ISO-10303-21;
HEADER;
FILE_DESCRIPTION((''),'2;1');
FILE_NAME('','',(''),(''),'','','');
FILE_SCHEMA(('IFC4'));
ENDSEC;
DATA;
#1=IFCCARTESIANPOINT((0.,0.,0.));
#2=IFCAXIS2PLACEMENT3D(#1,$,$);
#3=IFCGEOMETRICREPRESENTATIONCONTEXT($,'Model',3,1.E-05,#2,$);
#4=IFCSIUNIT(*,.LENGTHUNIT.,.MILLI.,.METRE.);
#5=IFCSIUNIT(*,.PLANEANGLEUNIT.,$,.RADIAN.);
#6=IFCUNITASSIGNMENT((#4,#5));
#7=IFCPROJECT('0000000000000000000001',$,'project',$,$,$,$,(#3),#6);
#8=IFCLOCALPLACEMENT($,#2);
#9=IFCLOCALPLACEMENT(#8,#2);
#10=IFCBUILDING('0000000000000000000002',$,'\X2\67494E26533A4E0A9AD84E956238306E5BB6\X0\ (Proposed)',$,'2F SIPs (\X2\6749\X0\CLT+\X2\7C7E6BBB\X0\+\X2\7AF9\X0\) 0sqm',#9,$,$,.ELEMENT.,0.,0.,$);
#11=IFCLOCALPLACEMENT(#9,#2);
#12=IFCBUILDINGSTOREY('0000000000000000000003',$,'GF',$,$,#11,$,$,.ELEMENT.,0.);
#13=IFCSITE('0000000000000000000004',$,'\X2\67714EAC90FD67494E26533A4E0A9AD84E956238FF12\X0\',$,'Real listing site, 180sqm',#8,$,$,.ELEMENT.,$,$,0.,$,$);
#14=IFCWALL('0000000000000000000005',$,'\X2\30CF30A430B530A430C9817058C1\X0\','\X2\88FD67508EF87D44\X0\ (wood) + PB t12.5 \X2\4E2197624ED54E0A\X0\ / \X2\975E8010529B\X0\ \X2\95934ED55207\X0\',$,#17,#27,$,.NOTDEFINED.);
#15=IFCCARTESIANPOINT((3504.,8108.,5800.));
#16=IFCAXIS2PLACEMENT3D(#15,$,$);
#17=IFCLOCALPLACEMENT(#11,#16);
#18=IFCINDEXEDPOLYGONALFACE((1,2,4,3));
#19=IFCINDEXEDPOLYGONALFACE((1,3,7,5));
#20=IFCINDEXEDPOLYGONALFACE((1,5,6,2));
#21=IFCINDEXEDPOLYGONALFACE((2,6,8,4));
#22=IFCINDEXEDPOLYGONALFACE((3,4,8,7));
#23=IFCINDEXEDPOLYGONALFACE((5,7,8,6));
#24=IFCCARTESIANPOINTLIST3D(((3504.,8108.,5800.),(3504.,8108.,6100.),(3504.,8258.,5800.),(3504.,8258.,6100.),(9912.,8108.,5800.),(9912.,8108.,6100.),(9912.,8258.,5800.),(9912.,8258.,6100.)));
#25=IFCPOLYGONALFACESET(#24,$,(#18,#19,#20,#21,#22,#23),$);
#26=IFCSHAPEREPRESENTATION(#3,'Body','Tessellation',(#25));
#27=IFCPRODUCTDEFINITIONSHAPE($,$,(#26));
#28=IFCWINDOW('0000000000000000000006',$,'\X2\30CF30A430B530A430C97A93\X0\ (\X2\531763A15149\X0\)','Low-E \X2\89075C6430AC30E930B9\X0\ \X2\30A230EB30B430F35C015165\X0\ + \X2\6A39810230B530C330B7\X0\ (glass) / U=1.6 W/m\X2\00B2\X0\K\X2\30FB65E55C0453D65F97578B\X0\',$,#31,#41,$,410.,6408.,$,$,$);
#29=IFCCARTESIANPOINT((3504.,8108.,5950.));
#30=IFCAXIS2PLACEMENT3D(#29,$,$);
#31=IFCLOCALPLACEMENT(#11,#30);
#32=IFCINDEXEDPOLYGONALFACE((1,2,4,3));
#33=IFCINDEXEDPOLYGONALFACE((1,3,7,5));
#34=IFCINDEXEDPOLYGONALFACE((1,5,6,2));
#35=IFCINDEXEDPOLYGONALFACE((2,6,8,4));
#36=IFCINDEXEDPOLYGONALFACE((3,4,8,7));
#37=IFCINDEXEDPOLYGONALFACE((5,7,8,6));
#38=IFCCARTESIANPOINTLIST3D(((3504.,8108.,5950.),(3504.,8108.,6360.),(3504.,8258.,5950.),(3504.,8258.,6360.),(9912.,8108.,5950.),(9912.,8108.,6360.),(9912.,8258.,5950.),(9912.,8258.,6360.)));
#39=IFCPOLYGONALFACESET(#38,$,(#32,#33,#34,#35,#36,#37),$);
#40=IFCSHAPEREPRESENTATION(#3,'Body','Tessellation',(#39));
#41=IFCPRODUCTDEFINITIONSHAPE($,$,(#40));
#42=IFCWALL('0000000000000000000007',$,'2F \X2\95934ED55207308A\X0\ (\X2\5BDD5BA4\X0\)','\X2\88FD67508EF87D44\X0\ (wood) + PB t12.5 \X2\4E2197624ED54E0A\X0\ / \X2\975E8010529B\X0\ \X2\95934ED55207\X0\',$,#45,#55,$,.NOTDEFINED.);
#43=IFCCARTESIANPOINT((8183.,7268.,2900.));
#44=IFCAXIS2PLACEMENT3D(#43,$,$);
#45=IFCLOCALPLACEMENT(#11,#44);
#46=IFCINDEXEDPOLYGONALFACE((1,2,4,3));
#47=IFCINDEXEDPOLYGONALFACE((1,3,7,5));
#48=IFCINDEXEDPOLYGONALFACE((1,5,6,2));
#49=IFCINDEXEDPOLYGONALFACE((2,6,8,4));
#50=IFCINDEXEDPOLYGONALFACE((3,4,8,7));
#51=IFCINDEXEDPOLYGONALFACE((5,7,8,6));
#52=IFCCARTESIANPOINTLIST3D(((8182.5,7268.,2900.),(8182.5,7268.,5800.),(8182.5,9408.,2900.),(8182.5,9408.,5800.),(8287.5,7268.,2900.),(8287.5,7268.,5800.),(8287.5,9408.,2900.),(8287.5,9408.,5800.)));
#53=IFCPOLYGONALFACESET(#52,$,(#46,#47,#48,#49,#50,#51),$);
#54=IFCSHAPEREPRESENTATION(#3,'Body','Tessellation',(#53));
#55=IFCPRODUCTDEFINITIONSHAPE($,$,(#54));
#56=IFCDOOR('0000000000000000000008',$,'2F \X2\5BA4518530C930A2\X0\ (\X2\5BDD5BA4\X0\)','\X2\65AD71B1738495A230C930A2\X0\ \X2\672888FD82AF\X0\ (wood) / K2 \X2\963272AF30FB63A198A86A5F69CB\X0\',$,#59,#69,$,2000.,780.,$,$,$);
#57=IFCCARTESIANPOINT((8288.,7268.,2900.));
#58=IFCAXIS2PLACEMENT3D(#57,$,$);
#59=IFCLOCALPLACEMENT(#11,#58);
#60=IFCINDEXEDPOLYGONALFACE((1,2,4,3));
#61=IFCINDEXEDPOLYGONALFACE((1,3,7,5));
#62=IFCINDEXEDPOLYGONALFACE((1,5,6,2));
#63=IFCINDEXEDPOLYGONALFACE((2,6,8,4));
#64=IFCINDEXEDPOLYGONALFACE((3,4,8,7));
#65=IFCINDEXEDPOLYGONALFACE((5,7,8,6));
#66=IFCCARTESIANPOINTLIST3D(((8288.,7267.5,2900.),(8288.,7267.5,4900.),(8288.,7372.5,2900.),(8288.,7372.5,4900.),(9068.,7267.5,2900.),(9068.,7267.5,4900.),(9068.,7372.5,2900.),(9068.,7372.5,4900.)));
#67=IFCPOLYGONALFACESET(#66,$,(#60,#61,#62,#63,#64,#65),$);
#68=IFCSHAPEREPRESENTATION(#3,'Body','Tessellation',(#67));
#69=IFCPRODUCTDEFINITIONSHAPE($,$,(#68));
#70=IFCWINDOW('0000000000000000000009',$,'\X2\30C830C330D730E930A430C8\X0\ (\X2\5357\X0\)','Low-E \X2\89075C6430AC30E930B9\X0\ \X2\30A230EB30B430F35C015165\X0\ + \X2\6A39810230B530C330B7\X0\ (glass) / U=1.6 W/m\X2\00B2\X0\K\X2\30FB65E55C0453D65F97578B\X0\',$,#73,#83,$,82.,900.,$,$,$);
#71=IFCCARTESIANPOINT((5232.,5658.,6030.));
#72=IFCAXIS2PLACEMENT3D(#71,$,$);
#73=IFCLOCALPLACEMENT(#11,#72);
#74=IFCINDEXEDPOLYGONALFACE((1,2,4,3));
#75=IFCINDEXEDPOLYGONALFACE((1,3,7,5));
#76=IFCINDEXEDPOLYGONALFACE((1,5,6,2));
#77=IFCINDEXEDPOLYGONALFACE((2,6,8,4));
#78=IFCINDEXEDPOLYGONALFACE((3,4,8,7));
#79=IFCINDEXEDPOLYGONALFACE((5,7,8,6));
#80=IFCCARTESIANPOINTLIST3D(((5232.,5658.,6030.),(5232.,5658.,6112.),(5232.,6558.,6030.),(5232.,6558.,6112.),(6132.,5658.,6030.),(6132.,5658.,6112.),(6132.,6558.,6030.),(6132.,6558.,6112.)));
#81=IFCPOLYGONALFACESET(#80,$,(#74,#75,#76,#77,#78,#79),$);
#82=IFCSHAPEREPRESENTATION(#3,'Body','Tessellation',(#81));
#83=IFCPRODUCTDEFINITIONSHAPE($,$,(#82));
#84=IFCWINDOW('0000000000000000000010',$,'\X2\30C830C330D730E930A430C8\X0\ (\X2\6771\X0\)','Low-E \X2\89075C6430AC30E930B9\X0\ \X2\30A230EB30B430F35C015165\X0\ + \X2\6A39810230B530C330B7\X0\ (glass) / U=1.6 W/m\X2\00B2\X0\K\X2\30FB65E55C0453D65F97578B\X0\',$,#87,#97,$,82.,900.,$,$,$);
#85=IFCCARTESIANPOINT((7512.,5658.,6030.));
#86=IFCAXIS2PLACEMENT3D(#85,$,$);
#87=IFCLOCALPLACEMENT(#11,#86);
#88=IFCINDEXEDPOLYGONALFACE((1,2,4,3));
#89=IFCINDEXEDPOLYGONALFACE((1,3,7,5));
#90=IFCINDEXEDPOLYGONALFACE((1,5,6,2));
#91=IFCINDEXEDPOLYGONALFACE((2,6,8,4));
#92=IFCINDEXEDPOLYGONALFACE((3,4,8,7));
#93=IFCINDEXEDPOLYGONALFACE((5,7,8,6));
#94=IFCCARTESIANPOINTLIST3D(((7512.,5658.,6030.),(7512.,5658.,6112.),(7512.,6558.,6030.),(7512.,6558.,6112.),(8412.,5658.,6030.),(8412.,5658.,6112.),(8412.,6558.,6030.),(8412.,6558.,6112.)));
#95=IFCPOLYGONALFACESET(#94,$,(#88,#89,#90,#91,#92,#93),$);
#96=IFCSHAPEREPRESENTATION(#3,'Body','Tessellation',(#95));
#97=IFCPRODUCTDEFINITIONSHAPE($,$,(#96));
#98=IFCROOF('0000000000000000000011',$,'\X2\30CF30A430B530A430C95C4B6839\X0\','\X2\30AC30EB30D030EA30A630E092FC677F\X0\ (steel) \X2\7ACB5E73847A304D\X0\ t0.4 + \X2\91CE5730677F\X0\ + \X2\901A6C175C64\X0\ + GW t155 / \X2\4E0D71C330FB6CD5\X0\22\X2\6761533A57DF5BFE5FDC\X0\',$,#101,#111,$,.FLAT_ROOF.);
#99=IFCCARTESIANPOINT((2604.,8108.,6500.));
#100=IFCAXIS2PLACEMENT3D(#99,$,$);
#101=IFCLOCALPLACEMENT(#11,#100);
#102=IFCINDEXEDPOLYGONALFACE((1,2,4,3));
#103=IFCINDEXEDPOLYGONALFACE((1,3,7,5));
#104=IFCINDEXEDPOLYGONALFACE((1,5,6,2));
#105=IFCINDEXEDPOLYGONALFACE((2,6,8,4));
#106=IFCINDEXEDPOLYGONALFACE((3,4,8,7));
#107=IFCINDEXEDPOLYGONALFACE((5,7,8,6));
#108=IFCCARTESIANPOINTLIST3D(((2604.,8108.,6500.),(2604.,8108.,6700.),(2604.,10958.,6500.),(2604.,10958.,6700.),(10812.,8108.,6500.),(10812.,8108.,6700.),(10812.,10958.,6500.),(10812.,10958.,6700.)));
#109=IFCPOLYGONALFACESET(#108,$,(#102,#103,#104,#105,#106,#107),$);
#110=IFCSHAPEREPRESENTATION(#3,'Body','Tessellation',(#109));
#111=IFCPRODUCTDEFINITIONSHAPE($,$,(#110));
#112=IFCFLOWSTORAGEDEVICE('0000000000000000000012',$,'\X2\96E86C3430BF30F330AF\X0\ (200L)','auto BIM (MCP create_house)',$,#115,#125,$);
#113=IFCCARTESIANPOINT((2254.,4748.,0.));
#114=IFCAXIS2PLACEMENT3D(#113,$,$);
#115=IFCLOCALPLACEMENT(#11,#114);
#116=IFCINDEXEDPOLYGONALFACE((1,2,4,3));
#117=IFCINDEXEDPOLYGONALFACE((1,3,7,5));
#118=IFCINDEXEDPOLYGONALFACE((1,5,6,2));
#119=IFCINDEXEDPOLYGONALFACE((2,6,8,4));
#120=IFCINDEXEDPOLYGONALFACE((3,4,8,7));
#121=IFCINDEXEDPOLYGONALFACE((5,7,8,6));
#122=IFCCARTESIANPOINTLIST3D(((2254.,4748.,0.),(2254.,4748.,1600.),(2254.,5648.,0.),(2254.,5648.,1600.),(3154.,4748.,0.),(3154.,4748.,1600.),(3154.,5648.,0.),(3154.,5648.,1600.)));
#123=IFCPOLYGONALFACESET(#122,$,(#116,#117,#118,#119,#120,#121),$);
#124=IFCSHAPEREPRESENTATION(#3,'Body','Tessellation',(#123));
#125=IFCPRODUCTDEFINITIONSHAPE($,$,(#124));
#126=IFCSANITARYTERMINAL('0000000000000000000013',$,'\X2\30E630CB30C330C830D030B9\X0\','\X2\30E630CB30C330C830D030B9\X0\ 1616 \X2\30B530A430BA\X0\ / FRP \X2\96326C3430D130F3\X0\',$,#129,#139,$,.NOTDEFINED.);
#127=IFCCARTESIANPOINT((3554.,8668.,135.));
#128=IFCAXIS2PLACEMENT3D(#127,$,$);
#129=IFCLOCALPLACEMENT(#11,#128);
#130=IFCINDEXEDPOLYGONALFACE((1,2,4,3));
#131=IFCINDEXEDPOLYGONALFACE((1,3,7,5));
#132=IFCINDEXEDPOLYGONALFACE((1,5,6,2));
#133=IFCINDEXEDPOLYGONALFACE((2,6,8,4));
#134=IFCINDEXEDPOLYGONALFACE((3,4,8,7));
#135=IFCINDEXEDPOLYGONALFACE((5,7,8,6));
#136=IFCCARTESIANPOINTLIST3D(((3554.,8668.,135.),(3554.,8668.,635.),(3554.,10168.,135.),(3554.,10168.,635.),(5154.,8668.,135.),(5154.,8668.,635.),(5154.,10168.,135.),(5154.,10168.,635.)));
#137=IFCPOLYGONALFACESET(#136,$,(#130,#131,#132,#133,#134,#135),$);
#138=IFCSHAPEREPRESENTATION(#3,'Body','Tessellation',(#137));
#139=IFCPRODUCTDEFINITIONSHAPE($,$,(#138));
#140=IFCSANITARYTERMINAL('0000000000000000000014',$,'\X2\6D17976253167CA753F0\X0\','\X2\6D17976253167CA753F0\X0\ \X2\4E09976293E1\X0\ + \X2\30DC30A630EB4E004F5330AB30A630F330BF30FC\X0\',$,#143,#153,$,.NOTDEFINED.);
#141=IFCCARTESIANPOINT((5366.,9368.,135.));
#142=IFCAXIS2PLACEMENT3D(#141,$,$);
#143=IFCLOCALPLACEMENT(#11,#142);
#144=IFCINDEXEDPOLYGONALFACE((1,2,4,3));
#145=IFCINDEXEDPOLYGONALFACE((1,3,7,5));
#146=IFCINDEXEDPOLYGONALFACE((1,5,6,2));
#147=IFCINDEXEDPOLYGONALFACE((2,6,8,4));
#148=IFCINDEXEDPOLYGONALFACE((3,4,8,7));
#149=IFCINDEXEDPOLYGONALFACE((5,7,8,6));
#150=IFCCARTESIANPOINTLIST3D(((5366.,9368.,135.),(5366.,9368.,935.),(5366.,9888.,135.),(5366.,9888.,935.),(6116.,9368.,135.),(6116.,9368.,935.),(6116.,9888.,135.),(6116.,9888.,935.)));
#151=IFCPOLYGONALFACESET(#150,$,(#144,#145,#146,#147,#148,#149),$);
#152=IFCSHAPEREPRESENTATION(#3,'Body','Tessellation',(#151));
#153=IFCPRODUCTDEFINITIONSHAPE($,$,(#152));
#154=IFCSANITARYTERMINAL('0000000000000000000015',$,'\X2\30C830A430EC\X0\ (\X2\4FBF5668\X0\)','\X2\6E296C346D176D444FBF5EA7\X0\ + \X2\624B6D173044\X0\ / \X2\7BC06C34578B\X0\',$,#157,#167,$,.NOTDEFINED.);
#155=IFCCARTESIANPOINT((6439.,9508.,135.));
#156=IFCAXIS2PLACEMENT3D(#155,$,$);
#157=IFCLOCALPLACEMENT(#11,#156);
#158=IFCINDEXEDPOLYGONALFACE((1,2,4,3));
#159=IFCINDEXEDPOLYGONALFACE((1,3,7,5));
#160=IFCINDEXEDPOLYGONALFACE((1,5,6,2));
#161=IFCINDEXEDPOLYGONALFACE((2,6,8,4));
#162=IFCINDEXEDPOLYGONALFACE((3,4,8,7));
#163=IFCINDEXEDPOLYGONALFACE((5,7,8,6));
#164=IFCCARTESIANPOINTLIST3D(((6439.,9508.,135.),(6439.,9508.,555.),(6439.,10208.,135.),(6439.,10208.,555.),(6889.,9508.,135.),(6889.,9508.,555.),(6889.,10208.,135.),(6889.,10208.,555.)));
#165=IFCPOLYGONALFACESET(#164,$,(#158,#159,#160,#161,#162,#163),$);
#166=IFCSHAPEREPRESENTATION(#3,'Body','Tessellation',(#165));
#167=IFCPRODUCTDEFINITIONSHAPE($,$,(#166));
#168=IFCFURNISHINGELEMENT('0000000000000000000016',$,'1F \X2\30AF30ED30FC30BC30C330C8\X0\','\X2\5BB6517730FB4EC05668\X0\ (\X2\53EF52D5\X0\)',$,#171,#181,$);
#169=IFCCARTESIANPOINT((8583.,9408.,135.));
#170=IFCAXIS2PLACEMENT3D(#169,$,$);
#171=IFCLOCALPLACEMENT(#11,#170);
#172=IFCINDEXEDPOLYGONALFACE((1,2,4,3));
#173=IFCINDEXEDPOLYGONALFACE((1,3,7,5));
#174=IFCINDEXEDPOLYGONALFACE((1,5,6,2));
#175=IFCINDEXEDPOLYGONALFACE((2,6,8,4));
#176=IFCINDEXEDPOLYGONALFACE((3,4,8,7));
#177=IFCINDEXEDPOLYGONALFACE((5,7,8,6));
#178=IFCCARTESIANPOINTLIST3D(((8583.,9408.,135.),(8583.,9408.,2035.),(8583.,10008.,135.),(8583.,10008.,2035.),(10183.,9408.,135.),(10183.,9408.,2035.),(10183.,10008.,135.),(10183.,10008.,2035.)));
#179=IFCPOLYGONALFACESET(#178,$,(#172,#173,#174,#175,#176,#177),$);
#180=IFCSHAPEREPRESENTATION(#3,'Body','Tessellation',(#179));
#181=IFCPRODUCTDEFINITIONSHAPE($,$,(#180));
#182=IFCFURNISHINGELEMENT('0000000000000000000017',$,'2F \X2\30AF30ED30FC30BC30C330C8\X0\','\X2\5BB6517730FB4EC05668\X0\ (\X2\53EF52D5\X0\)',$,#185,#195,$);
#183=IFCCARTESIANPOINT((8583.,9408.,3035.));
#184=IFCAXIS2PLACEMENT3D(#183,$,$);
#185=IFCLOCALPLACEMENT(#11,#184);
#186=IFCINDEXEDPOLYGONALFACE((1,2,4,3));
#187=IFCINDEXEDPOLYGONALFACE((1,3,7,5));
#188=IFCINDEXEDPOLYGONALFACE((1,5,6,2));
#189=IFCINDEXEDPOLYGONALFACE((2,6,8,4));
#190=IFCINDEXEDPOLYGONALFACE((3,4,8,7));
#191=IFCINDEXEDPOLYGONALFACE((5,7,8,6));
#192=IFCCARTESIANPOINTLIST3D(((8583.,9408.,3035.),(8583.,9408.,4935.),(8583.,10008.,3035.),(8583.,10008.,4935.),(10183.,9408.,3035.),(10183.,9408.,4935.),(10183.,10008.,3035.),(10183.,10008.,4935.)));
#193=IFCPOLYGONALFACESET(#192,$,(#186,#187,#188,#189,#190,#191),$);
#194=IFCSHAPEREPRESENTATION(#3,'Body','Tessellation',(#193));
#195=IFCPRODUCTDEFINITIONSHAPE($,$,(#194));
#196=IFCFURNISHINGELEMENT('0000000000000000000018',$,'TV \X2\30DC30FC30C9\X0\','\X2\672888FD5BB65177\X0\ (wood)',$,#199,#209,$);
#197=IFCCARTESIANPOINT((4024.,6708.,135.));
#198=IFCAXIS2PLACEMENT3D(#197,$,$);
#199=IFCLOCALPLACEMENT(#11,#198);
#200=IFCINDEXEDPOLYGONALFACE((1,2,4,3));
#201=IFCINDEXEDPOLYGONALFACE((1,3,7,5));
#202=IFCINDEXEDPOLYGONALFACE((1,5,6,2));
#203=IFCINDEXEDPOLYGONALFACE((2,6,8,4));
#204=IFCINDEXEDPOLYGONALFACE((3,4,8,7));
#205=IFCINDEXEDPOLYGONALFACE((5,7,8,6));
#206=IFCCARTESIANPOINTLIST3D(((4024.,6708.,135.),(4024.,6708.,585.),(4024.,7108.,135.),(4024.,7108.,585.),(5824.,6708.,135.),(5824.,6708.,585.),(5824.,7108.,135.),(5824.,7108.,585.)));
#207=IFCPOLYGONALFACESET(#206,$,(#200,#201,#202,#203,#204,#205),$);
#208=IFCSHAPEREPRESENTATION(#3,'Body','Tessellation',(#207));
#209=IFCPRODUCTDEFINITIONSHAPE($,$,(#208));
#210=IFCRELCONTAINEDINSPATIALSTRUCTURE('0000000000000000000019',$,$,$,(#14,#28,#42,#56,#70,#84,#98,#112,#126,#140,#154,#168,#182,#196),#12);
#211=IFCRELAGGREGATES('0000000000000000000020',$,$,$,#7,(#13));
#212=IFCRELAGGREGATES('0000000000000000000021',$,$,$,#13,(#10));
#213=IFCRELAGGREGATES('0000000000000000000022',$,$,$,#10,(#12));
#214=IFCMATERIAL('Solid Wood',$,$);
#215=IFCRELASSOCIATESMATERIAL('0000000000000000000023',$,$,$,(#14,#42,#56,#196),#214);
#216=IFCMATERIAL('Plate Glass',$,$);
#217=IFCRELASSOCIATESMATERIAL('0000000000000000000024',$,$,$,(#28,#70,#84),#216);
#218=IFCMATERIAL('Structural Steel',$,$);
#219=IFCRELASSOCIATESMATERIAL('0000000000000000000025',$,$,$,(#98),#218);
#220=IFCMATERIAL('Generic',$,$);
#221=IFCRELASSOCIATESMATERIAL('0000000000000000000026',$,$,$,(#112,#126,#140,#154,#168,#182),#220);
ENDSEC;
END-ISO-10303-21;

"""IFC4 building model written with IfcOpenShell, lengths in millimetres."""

from ifc_helpers import new_model, si_unit, frame, frame_2d, origin, place, context, project, spatial, rectangle, extrude, material, element, fill, save


model = new_model("IFC4")

# Units and contexts
model_context = context("Model", 3, precision=1e-05, world=origin())
ifc_project = project(units=[si_unit("LENGTHUNIT", "METRE", prefix="MILLI"), si_unit("PLANEANGLEUNIT", "RADIAN")], contexts=[model_context])

# Site, building, storey
site_placement = place(None, origin())
site = spatial("IfcSite", under=ifc_project, at=site_placement, Name="東京都杉並区上高井戸２", ObjectType="Real listing site, 180sqm", CompositionType="ELEMENT", RefElevation=0.0)
building_placement = place(site_placement, origin())
building = spatial("IfcBuilding", under=site, at=building_placement, Name="杉並区上高井戸の家 (Proposed)", ObjectType="2F SIPs (杉CLT+籾殻+竹) 0sqm", CompositionType="ELEMENT", ElevationOfRefHeight=0.0, ElevationOfTerrain=0.0)
storey_placement = place(building_placement, origin())
storey = spatial("IfcBuildingStorey", under=building, at=storey_placement, Name="GF", CompositionType="ELEMENT", Elevation=0.0)

# Shared definitions
ifc_material_1 = material(Name="Solid Wood")
ifc_material_2 = material(Name="Plate Glass")

# Wall, opening, window
wall_1_placement = place(storey_placement, frame((3504.0, 8108.0, 5800.0)))
wall_1 = element("IfcWall", 1, at=wall_1_placement, inside=storey, material=ifc_material_1, Name="ハイサイド腰壁", Description="製材軸組 (wood) + PB t12.5 両面仕上 / 非耐力 間仕切", PredefinedType="NOTDEFINED", context=model_context, shape_type="SweptSolid", body=[
    extrude(rectangle(XDim=6408.0, YDim=150.0, at=frame_2d((3204.0, 75.0))), frame((3504.0, 8108.0, 5800.0)), (0.0, 0.0, 1.0), 700.0),
])
opening_1_placement = place(storey_placement, frame((3504.0, 8108.0, 5950.0)))
opening_1 = element("IfcOpeningElement", 2, at=opening_1_placement, cuts=wall_1, PredefinedType="NOTDEFINED", context=model_context, shape_type="SweptSolid", body=[
    extrude(rectangle(XDim=6408.0, YDim=150.0, at=frame_2d((3204.0, 75.0))), frame((3504.0, 8108.0, 5950.0)), (0.0, 0.0, 1.0), 410.0),
])
window_1_placement = place(storey_placement, frame((3504.0, 8108.0, 5950.0)))
window_1 = element("IfcWindow", 3, at=window_1_placement, inside=storey, material=ifc_material_2, Name="ハイサイド窓 (北採光)", Description="Low-E 複層ガラス アルゴン封入 + 樹脂サッシ (glass) / U=1.6 W/m²K・日射取得型", OverallHeight=410.0, OverallWidth=6408.0, context=model_context, shape_type="SweptSolid", body=[
    extrude(rectangle(XDim=6408.0, YDim=150.0, at=frame_2d((3204.0, 75.0))), frame((3504.0, 8108.0, 5950.0)), (0.0, 0.0, 1.0), 410.0),
])
fill(opening_1, window_1)

# Wall
wall_2_placement = place(storey_placement, frame((8183.0, 7268.0, 2900.0)))
element("IfcWall", 4, at=wall_2_placement, inside=storey, material=ifc_material_1, Name="2F 間仕切り (寝室)", Description="製材軸組 (wood) + PB t12.5 両面仕上 / 非耐力 間仕切", PredefinedType="NOTDEFINED", context=model_context, shape_type="SweptSolid", body=[
    extrude(rectangle(XDim=105.0, YDim=2140.0, at=frame_2d((52.0, 1070.0))), frame((8183.0, 7268.0, 2900.0)), (0.0, 0.0, 1.0), 2900.0),
])

# Door
door_1_placement = place(storey_placement, frame((8288.0, 7268.0, 2900.0)))
element("IfcDoor", 5, at=door_1_placement, inside=storey, material=ifc_material_1, Name="2F 室内ドア (寝室)", Description="断熱玄関ドア 木製芯 (wood) / K2 防犯・採風機構", OverallHeight=2000.0, OverallWidth=780.0, context=model_context, shape_type="SweptSolid", body=[
    extrude(rectangle(XDim=780.0, YDim=105.0, at=frame_2d((390.0, 52.0))), frame((8288.0, 7268.0, 2900.0)), (0.0, 0.0, 1.0), 2000.0),
])

# Windows
window_2_placement = place(storey_placement, frame((5232.0, 5658.0, 6030.0)))
element("IfcWindow", 6, at=window_2_placement, inside=storey, material=ifc_material_2, Name="トップライト (南)", Description="Low-E 複層ガラス アルゴン封入 + 樹脂サッシ (glass) / U=1.6 W/m²K・日射取得型", OverallHeight=82.0, OverallWidth=900.0, context=model_context, shape_type="SweptSolid", body=[
    extrude(rectangle(XDim=900.0, YDim=900.0, at=frame_2d((450.0, 450.0))), frame((5232.0, 5658.0, 6030.0)), (0.0, 0.0, 1.0), 82.0),
])
window_3_placement = place(storey_placement, frame((7512.0, 5658.0, 6030.0)))
element("IfcWindow", 7, at=window_3_placement, inside=storey, material=ifc_material_2, Name="トップライト (東)", Description="Low-E 複層ガラス アルゴン封入 + 樹脂サッシ (glass) / U=1.6 W/m²K・日射取得型", OverallHeight=82.0, OverallWidth=900.0, context=model_context, shape_type="SweptSolid", body=[
    extrude(rectangle(XDim=900.0, YDim=900.0, at=frame_2d((450.0, 450.0))), frame((7512.0, 5658.0, 6030.0)), (0.0, 0.0, 1.0), 82.0),
])

# Roof
ifc_material_3 = material(Name="Structural Steel")
roof_placement = place(storey_placement, frame((2604.0, 8108.0, 6500.0)))
element("IfcRoof", 8, at=roof_placement, inside=storey, material=ifc_material_3, Name="ハイサイド屋根", Description="ガルバリウム鋼板 (steel) 立平葺き t0.4 + 野地板 + 通気層 + GW t155 / 不燃・法22条区域対応", PredefinedType="FLAT_ROOF", context=model_context, shape_type="SweptSolid", body=[
    extrude(rectangle(XDim=8208.0, YDim=2850.0, at=frame_2d((4104.0, 1425.0))), frame((2604.0, 8108.0, 6500.0)), (0.0, 0.0, 1.0), 200.0),
])

# Flow storage device
ifc_material_4 = material(Name="Generic")
flow_storage_device_placement = place(storey_placement, frame((2254.0, 4748.0, 0.0)))
element("IfcFlowStorageDevice", 9, at=flow_storage_device_placement, inside=storey, material=ifc_material_4, Name="雨水タンク (200L)", Description="auto BIM (MCP create_house)", context=model_context, shape_type="SweptSolid", body=[
    extrude(rectangle(XDim=900.0, YDim=900.0, at=frame_2d((450.0, 450.0))), frame((2254.0, 4748.0, 0.0)), (0.0, 0.0, 1.0), 1600.0),
])

# Sanitary terminals
sanitary_terminal_1_placement = place(storey_placement, frame((3554.0, 8668.0, 135.0)))
element("IfcSanitaryTerminal", 10, at=sanitary_terminal_1_placement, inside=storey, material=ifc_material_4, Name="ユニットバス", Description="ユニットバス 1616 サイズ / FRP 防水パン", PredefinedType="NOTDEFINED", context=model_context, shape_type="SweptSolid", body=[
    extrude(rectangle(XDim=1600.0, YDim=1500.0, at=frame_2d((800.0, 750.0))), frame((3554.0, 8668.0, 135.0)), (0.0, 0.0, 1.0), 500.0),
])
sanitary_terminal_2_placement = place(storey_placement, frame((5366.0, 9368.0, 135.0)))
element("IfcSanitaryTerminal", 11, at=sanitary_terminal_2_placement, inside=storey, material=ifc_material_4, Name="洗面化粧台", Description="洗面化粧台 三面鏡 + ボウル一体カウンター", PredefinedType="NOTDEFINED", context=model_context, shape_type="SweptSolid", body=[
    extrude(rectangle(XDim=750.0, YDim=520.0, at=frame_2d((375.0, 260.0))), frame((5366.0, 9368.0, 135.0)), (0.0, 0.0, 1.0), 800.0),
])
sanitary_terminal_3_placement = place(storey_placement, frame((6439.0, 9508.0, 135.0)))
element("IfcSanitaryTerminal", 12, at=sanitary_terminal_3_placement, inside=storey, material=ifc_material_4, Name="トイレ (便器)", Description="温水洗浄便座 + 手洗い / 節水型", PredefinedType="NOTDEFINED", context=model_context, shape_type="SweptSolid", body=[
    extrude(rectangle(XDim=450.0, YDim=700.0, at=frame_2d((225.0, 350.0))), frame((6439.0, 9508.0, 135.0)), (0.0, 0.0, 1.0), 420.0),
])

# Furnishing elements
furnishing_1_placement = place(storey_placement, frame((8583.0, 9408.0, 135.0)))
element("IfcFurnishingElement", 13, at=furnishing_1_placement, inside=storey, material=ifc_material_4, Name="1F クローゼット", Description="家具・什器 (可動)", context=model_context, shape_type="SweptSolid", body=[
    extrude(rectangle(XDim=1600.0, YDim=600.0, at=frame_2d((800.0, 300.0))), frame((8583.0, 9408.0, 135.0)), (0.0, 0.0, 1.0), 1900.0),
])
furnishing_2_placement = place(storey_placement, frame((8583.0, 9408.0, 3035.0)))
element("IfcFurnishingElement", 14, at=furnishing_2_placement, inside=storey, material=ifc_material_4, Name="2F クローゼット", Description="家具・什器 (可動)", context=model_context, shape_type="SweptSolid", body=[
    extrude(rectangle(XDim=1600.0, YDim=600.0, at=frame_2d((800.0, 300.0))), frame((8583.0, 9408.0, 3035.0)), (0.0, 0.0, 1.0), 1900.0),
])
furnishing_3_placement = place(storey_placement, frame((4024.0, 6708.0, 135.0)))
element("IfcFurnishingElement", 15, at=furnishing_3_placement, inside=storey, material=ifc_material_1, Name="TV ボード", Description="木製家具 (wood)", context=model_context, shape_type="SweptSolid", body=[
    extrude(rectangle(XDim=1800.0, YDim=400.0, at=frame_2d((900.0, 200.0))), frame((4024.0, 6708.0, 135.0)), (0.0, 0.0, 1.0), 450.0),
])

save(model, "model.ifc")
